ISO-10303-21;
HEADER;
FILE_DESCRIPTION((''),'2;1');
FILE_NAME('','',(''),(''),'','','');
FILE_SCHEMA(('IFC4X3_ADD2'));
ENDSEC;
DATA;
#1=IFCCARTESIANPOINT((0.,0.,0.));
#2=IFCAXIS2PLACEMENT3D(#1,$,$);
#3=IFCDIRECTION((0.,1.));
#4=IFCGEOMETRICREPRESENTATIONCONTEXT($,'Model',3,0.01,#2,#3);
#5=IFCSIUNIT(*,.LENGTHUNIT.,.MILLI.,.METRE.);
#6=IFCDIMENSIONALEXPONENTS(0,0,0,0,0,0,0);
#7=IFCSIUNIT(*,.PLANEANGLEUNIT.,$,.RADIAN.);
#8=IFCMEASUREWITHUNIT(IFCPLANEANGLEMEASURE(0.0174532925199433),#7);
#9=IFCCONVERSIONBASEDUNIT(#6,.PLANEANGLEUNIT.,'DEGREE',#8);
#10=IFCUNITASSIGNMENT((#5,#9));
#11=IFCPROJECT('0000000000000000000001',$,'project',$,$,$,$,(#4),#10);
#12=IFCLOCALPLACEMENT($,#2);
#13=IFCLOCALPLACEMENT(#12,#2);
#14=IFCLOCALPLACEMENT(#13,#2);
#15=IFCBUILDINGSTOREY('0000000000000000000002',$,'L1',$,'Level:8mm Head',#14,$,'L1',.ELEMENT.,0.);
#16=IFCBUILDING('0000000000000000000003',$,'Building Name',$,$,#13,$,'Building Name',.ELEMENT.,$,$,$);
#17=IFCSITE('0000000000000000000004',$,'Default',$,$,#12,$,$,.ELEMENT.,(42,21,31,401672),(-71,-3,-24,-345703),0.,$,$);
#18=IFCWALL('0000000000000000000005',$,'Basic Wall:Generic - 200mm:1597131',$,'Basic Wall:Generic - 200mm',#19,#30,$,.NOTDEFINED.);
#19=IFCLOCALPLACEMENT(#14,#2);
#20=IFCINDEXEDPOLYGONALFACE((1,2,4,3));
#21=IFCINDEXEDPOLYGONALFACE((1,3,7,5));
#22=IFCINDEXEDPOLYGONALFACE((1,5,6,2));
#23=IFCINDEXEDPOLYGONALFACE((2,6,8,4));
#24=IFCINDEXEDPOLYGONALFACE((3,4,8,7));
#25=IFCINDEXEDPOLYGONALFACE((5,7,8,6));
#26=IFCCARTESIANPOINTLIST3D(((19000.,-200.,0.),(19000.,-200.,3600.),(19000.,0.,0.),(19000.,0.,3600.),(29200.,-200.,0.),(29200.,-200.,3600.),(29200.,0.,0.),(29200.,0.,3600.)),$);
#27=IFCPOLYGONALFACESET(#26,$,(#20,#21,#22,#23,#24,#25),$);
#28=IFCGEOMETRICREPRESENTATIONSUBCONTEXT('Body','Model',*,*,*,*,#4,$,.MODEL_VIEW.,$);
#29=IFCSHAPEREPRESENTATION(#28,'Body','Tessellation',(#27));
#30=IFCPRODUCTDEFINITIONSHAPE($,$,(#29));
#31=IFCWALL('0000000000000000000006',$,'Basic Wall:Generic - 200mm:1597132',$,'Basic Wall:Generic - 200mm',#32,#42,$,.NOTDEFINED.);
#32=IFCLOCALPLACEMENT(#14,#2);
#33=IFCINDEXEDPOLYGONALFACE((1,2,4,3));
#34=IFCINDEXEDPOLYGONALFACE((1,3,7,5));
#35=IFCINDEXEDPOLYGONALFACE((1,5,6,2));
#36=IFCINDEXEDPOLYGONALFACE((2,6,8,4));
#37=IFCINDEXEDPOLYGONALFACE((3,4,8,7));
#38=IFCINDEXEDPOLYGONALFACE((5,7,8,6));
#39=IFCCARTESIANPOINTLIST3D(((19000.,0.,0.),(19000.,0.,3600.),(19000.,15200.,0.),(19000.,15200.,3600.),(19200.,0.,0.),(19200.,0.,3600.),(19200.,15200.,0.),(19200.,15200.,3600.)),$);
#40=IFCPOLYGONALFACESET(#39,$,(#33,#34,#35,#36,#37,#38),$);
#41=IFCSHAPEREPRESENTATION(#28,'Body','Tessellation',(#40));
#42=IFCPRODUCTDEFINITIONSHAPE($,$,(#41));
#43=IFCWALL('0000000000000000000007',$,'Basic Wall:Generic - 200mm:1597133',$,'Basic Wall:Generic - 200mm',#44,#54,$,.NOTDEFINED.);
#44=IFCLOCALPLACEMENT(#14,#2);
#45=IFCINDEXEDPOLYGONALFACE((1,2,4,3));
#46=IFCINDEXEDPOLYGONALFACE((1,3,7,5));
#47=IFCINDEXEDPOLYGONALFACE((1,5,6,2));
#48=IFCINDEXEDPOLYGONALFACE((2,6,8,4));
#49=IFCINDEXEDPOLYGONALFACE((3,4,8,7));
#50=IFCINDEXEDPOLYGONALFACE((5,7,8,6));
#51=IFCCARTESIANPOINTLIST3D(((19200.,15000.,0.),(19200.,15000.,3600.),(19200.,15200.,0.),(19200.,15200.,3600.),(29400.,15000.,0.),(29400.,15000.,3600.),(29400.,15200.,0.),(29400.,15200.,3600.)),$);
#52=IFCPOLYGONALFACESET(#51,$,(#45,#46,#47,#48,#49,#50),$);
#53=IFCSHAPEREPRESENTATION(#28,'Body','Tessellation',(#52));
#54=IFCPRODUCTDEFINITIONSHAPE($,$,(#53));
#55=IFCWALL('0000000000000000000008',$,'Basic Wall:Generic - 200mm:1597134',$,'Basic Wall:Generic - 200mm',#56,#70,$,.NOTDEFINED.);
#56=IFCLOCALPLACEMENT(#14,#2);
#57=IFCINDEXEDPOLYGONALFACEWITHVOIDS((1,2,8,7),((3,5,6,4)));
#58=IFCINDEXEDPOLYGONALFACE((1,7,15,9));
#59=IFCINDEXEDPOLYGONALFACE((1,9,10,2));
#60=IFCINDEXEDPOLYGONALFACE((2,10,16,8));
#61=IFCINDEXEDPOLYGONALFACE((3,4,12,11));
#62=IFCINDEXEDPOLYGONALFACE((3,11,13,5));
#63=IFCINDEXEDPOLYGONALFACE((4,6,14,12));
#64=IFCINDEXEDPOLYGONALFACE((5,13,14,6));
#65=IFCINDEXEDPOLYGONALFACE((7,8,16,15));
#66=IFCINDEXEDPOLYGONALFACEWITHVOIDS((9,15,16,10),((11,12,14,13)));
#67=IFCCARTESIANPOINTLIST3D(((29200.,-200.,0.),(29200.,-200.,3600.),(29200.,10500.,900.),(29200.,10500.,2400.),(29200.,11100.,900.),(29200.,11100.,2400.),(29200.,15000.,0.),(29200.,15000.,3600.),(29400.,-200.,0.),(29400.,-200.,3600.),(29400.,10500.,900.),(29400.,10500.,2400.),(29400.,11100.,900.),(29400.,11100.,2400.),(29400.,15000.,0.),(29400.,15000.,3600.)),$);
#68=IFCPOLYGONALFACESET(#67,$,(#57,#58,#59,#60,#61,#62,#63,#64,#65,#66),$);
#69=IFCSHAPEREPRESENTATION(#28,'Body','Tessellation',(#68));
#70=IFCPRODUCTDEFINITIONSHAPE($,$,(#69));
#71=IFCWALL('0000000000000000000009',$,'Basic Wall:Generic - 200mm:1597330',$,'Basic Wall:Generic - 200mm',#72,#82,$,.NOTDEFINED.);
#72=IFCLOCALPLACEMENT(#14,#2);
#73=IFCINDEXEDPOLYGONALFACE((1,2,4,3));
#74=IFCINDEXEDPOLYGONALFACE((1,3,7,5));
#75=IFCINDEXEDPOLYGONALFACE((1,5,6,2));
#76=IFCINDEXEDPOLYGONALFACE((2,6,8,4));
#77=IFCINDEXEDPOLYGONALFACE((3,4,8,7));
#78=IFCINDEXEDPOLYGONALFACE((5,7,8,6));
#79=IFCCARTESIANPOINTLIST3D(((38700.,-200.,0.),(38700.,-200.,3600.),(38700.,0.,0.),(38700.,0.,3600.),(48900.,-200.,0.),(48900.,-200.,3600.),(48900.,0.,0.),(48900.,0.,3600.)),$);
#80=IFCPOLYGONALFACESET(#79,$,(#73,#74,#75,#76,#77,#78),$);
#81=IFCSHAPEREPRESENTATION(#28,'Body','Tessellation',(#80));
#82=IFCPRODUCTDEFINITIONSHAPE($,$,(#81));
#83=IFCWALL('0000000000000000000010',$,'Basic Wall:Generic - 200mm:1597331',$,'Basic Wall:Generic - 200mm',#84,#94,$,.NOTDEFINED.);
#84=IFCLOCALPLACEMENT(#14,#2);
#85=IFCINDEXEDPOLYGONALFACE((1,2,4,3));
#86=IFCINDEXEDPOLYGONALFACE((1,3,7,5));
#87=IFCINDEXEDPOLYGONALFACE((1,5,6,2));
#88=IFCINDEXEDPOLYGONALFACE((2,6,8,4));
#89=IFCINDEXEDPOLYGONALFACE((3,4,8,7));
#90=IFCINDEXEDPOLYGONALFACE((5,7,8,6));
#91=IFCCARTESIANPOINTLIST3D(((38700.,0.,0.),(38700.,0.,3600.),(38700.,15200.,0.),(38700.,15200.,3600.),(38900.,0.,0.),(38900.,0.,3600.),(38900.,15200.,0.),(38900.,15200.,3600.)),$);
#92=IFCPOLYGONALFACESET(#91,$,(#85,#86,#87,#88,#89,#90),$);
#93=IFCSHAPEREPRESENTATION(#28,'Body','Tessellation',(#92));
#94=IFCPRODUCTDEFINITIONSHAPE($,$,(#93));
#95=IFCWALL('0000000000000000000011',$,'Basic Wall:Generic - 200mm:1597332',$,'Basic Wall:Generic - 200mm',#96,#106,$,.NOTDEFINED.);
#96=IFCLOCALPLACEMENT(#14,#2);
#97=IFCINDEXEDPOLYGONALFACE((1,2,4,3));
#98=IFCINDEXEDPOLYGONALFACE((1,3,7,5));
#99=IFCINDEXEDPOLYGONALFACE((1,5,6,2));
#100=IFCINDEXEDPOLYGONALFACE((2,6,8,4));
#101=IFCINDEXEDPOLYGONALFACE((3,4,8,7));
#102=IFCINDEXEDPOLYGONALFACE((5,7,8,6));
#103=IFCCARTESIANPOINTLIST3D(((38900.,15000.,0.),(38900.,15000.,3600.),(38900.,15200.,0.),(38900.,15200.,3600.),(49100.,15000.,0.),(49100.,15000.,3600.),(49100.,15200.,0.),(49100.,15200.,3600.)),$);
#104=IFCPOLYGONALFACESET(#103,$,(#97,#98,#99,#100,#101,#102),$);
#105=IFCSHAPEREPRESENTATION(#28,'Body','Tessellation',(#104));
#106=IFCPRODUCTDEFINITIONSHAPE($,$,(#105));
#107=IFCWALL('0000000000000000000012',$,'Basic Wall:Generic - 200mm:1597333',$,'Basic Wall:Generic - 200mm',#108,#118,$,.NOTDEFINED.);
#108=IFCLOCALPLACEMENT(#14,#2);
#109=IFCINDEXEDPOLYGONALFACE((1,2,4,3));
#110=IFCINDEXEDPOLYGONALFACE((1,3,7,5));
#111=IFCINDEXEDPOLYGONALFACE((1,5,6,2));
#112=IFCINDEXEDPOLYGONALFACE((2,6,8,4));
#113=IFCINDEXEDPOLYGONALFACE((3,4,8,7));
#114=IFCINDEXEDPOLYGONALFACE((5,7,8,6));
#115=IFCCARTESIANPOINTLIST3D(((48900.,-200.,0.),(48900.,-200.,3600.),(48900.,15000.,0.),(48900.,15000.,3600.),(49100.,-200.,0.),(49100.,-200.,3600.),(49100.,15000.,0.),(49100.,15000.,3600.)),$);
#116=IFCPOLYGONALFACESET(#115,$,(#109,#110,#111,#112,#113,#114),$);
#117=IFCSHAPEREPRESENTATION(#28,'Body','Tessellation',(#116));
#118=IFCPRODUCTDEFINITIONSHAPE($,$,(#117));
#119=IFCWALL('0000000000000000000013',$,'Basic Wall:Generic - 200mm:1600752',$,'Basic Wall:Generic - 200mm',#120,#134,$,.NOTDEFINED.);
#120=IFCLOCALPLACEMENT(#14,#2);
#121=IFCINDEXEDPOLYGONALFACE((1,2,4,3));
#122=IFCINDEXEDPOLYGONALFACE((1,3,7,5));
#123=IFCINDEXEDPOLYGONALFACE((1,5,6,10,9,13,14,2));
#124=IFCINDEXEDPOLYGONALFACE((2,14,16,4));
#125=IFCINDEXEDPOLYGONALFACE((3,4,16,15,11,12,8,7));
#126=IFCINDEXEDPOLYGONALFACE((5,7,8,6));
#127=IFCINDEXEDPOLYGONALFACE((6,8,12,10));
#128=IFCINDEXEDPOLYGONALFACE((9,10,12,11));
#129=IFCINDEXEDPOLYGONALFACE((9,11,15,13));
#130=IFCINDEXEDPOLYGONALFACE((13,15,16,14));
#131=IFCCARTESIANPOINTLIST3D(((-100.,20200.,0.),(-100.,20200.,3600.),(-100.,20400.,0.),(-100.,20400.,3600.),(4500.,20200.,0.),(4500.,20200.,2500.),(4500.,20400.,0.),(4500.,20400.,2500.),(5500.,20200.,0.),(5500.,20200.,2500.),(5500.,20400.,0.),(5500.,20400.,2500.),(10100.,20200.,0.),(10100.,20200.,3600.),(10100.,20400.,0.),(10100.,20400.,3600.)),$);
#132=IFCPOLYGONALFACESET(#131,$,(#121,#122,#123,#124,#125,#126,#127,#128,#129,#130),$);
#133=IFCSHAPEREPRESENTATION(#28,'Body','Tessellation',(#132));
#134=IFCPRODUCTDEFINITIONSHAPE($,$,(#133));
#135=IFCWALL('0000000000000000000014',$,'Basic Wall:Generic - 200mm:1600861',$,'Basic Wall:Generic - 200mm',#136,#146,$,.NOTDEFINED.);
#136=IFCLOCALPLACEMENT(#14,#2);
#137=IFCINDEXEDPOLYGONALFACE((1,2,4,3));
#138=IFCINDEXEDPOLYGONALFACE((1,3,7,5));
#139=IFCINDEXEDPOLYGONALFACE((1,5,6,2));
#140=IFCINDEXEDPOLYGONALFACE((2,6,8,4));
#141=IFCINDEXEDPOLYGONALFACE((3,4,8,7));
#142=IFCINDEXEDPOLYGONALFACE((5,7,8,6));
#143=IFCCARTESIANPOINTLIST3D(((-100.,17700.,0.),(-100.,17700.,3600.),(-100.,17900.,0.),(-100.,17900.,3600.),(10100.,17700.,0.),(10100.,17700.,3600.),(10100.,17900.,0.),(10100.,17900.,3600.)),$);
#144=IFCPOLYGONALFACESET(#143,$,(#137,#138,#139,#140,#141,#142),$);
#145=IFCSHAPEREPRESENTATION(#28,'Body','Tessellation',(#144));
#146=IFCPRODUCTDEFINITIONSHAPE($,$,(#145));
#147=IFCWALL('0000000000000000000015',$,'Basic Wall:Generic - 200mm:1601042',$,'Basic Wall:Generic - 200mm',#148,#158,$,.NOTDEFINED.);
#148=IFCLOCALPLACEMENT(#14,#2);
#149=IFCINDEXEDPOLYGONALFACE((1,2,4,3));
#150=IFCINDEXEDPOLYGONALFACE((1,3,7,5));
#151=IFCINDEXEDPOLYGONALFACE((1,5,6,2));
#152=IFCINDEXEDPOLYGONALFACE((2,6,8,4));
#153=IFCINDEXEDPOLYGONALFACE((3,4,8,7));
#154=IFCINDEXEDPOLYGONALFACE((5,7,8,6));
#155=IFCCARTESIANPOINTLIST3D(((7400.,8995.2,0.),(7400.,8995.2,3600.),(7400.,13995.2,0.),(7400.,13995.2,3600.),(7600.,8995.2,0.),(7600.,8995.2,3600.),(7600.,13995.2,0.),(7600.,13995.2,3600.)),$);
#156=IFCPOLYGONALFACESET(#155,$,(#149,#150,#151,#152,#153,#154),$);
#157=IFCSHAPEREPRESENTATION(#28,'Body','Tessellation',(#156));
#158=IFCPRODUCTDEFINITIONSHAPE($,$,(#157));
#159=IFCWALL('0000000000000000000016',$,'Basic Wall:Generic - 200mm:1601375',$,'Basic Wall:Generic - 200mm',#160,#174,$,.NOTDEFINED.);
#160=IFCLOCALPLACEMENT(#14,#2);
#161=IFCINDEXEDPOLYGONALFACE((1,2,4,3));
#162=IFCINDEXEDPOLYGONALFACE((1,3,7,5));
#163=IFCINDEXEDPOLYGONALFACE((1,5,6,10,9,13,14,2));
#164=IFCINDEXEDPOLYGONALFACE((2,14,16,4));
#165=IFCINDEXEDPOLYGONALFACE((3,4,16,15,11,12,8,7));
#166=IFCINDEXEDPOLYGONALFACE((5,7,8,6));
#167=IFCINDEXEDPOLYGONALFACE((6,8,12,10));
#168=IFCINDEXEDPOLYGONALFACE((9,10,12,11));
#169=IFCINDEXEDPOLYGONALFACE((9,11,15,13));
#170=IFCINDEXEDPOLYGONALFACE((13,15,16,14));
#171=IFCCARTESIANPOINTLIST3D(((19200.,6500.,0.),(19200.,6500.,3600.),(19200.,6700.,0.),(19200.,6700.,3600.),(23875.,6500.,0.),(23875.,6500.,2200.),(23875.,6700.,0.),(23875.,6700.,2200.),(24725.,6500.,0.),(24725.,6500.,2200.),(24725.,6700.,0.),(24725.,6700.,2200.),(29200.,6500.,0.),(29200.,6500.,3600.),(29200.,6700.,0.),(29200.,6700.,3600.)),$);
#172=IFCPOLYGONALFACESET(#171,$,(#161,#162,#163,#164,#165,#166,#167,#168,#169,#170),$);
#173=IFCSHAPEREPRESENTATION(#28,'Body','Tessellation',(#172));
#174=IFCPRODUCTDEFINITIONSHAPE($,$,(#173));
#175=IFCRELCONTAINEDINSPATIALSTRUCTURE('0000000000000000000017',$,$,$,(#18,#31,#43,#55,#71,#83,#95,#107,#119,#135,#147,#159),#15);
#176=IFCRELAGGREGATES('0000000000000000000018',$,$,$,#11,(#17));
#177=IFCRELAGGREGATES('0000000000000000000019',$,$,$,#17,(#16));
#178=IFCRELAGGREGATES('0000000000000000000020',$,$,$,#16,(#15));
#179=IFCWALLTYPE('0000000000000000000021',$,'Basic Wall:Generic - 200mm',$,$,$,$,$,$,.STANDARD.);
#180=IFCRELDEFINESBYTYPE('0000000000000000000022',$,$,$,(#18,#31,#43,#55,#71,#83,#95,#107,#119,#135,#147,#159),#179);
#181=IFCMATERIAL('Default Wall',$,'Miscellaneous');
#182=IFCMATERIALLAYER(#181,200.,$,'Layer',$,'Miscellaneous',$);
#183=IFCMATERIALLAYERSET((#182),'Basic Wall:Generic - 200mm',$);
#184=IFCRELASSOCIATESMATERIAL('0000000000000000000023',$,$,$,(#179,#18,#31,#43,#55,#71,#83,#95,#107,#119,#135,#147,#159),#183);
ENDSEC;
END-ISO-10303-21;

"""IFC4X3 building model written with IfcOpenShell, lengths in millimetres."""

from ifc_helpers import new_model, entity, si_unit, converted_unit, direction, frame, frame_2d, origin, origin_2d_with_axis, place, context, subcontext, project, spatial, rectangle, extrude, material, layer, layer_set, type_object, element, save


model = new_model("IFC4X3")

# Units and contexts
model_context = context("Model", 3, precision=0.01, world=origin(), true_north=direction((0.0, 1.0)))
body_context = subcontext(model_context, "Body", "Model", "MODEL_VIEW")
ifc_project = project(units=[si_unit("LENGTHUNIT", "METRE", prefix="MILLI"), converted_unit("PLANEANGLEUNIT", "DEGREE", entity("IfcPlaneAngleMeasure", 0.0174532925199433), si_unit("PLANEANGLEUNIT", "RADIAN"), dimensions=[0, 0, 0, 0, 0, 0, 0])], contexts=[model_context])

# Site, building, storey
site_placement = place(None, origin())
site = spatial("IfcSite", under=ifc_project, at=site_placement, Name="Default", CompositionType="ELEMENT", RefLatitude=(42, 21, 31, 401672), RefLongitude=(-71, -3, -24, -345703), RefElevation=0.0)
building_placement = place(site_placement, origin())
building = spatial("IfcBuilding", under=site, at=building_placement, Name="Building Name", LongName="Building Name", CompositionType="ELEMENT")
storey_placement = place(building_placement, origin())
storey = spatial("IfcBuildingStorey", under=building, at=storey_placement, Name="L1", ObjectType="Level:8mm Head", LongName="L1", CompositionType="ELEMENT", Elevation=0.0)

# Walls
ifc_material_1 = material(Name="Default Wall", Category="Miscellaneous")
ifc_layer_1 = layer(ifc_material_1, 200.0, Name="Layer", Category="Miscellaneous")
ifc_layer_set_1 = layer_set([ifc_layer_1], Name="Basic Wall:Generic - 200mm")
wall_type_1 = type_object("IfcWallType", Name="Basic Wall:Generic - 200mm", PredefinedType="STANDARD", material=ifc_layer_set_1)
wall_1_placement = place(storey_placement, frame((19000.0, -100.0, 0.0)))
element("IfcWall", 1, at=wall_1_placement, inside=storey, type_object=wall_type_1, material=ifc_layer_set_1, Name="Basic Wall:Generic - 200mm:1597131", ObjectType="Basic Wall:Generic - 200mm", PredefinedType="NOTDEFINED", context=body_context, shape_type="SweptSolid", body=[
    extrude(rectangle(XDim=10200.0, YDim=200.0, at=frame_2d((5100.0, 0.0), x_axis=(-1.0, 0.0))), origin(), (0.0, 0.0, 1.0), 3600.0),
])
wall_2_placement = place(storey_placement, frame((19100.0, 15200.0, 0.0), z_axis=(0.0, 0.0, 1.0), x_axis=(0.0, -1.0, 0.0)))
element("IfcWall", 2, at=wall_2_placement, inside=storey, type_object=wall_type_1, material=ifc_layer_set_1, Name="Basic Wall:Generic - 200mm:1597132", ObjectType="Basic Wall:Generic - 200mm", PredefinedType="NOTDEFINED", context=body_context, shape_type="SweptSolid", body=[
    extrude(rectangle(XDim=15200.0, YDim=200.0, at=frame_2d((7600.0, 0.0), x_axis=(-1.0, 0.0))), origin(), (0.0, 0.0, 1.0), 3600.0),
])
wall_3_placement = place(storey_placement, frame((29400.0, 15100.0, 0.0), z_axis=(0.0, 0.0, 1.0), x_axis=(-1.0, 0.0, 0.0)))
element("IfcWall", 3, at=wall_3_placement, inside=storey, type_object=wall_type_1, material=ifc_layer_set_1, Name="Basic Wall:Generic - 200mm:1597133", ObjectType="Basic Wall:Generic - 200mm", PredefinedType="NOTDEFINED", context=body_context, shape_type="SweptSolid", body=[
    extrude(rectangle(XDim=10200.0, YDim=200.0, at=frame_2d((5100.0, 0.0), x_axis=(-1.0, 0.0))), origin(), (0.0, 0.0, 1.0), 3600.0),
])

# Wall, opening
wall_4_placement = place(storey_placement, frame((29300.0, -200.0, 0.0), z_axis=(0.0, 0.0, 1.0), x_axis=(0.0, 1.0, 0.0)))
wall_4 = element("IfcWall", 4, at=wall_4_placement, inside=storey, type_object=wall_type_1, material=ifc_layer_set_1, Name="Basic Wall:Generic - 200mm:1597134", ObjectType="Basic Wall:Generic - 200mm", PredefinedType="NOTDEFINED", context=body_context, shape_type="SweptSolid", body=[
    extrude(rectangle(XDim=15200.0, YDim=200.0, at=frame_2d((7600.0, 0.0), x_axis=(-1.0, 0.0))), origin(), (0.0, 0.0, 1.0), 3600.0),
])
opening_1_placement = place(wall_4_placement, frame((11300.0, 100.0, 900.0)))
element("IfcOpeningElement", 5, at=opening_1_placement, cuts=wall_4, PredefinedType="OPENING", context=body_context, shape_type="SweptSolid", body=[
    extrude(rectangle(XDim=1500.0, YDim=600.0, at=frame_2d((750.0, 300.0), x_axis=(-1.0, 0.0))), frame((0.0, 0.0, 0.0), z_axis=(0.0, -1.0, 0.0), x_axis=(0.0, 0.0, 1.0)), (0.0, 0.0, 1.0), 200.0),
])

# Walls
wall_5_placement = place(storey_placement, frame((38700.0, -100.0, 0.0)))
element("IfcWall", 6, at=wall_5_placement, inside=storey, type_object=wall_type_1, material=ifc_layer_set_1, Name="Basic Wall:Generic - 200mm:1597330", ObjectType="Basic Wall:Generic - 200mm", PredefinedType="NOTDEFINED", context=body_context, shape_type="SweptSolid", body=[
    extrude(rectangle(XDim=10200.0, YDim=200.0, at=frame_2d((5100.0, 0.0), x_axis=(-1.0, 0.0))), origin(), (0.0, 0.0, 1.0), 3600.0),
])
wall_6_placement = place(storey_placement, frame((38800.0, 15200.0, 0.0), z_axis=(0.0, 0.0, 1.0), x_axis=(0.0, -1.0, 0.0)))
element("IfcWall", 7, at=wall_6_placement, inside=storey, type_object=wall_type_1, material=ifc_layer_set_1, Name="Basic Wall:Generic - 200mm:1597331", ObjectType="Basic Wall:Generic - 200mm", PredefinedType="NOTDEFINED", context=body_context, shape_type="SweptSolid", body=[
    extrude(rectangle(XDim=15200.0, YDim=200.0, at=frame_2d((7600.0, 0.0), x_axis=(-1.0, 0.0))), origin(), (0.0, 0.0, 1.0), 3600.0),
])
wall_7_placement = place(storey_placement, frame((49100.0, 15100.0, 0.0), z_axis=(0.0, 0.0, 1.0), x_axis=(-1.0, 0.0, 0.0)))
element("IfcWall", 8, at=wall_7_placement, inside=storey, type_object=wall_type_1, material=ifc_layer_set_1, Name="Basic Wall:Generic - 200mm:1597332", ObjectType="Basic Wall:Generic - 200mm", PredefinedType="NOTDEFINED", context=body_context, shape_type="SweptSolid", body=[
    extrude(rectangle(XDim=10200.0, YDim=200.0, at=frame_2d((5100.0, 0.0), x_axis=(-1.0, 0.0))), origin(), (0.0, 0.0, 1.0), 3600.0),
])
wall_8_placement = place(storey_placement, frame((49000.0, -200.0, 0.0), z_axis=(0.0, 0.0, 1.0), x_axis=(0.0, 1.0, 0.0)))
element("IfcWall", 9, at=wall_8_placement, inside=storey, type_object=wall_type_1, material=ifc_layer_set_1, Name="Basic Wall:Generic - 200mm:1597333", ObjectType="Basic Wall:Generic - 200mm", PredefinedType="NOTDEFINED", context=body_context, shape_type="SweptSolid", body=[
    extrude(rectangle(XDim=15200.0, YDim=200.0, at=frame_2d((7600.0, 0.0), x_axis=(-1.0, 0.0))), origin(), (0.0, 0.0, 1.0), 3600.0),
])

# Wall, opening
wall_9_placement = place(storey_placement, frame((10100.0, 20300.0, 0.0), z_axis=(0.0, 0.0, 1.0), x_axis=(-1.0, 0.0, 0.0)))
wall_9 = element("IfcWall", 10, at=wall_9_placement, inside=storey, type_object=wall_type_1, material=ifc_layer_set_1, Name="Basic Wall:Generic - 200mm:1600752", ObjectType="Basic Wall:Generic - 200mm", PredefinedType="NOTDEFINED", context=body_context, shape_type="SweptSolid", body=[
    extrude(rectangle(XDim=10200.0, YDim=200.0, at=frame_2d((5100.0, 0.0), x_axis=(1.0, 0.0))), origin(), (0.0, 0.0, 1.0), 3600.0),
])
opening_2_placement = place(wall_9_placement, frame((5600.0, 100.0, 0.0)))
element("IfcOpeningElement", 11, at=opening_2_placement, cuts=wall_9, PredefinedType="OPENING", context=body_context, shape_type="SweptSolid", body=[
    extrude(rectangle(XDim=2500.0, YDim=1000.0, at=origin_2d_with_axis()), frame((-500.0, -200.0, 1250.0), z_axis=(0.0, 1.0, 0.0), x_axis=(0.0, 0.0, -1.0)), (0.0, 0.0, 1.0), 200.0),
])

# Walls
wall_10_placement = place(storey_placement, frame((10100.0, 17800.0, 0.0), z_axis=(0.0, 0.0, 1.0), x_axis=(-1.0, 0.0, 0.0)))
element("IfcWall", 12, at=wall_10_placement, inside=storey, type_object=wall_type_1, material=ifc_layer_set_1, Name="Basic Wall:Generic - 200mm:1600861", ObjectType="Basic Wall:Generic - 200mm", PredefinedType="NOTDEFINED", context=body_context, shape_type="SweptSolid", body=[
    extrude(rectangle(XDim=10200.0, YDim=200.0, at=frame_2d((5100.0, 0.0), x_axis=(-1.0, 0.0))), origin(), (0.0, 0.0, 1.0), 3600.0),
])
wall_11_placement = place(storey_placement, frame((7500.0, 13995.2, 0.0), z_axis=(0.0, 0.0, 1.0), x_axis=(0.0, -1.0, 0.0)))
element("IfcWall", 13, at=wall_11_placement, inside=storey, type_object=wall_type_1, material=ifc_layer_set_1, Name="Basic Wall:Generic - 200mm:1601042", ObjectType="Basic Wall:Generic - 200mm", PredefinedType="NOTDEFINED", context=body_context, shape_type="SweptSolid", body=[
    extrude(rectangle(XDim=5000.0, YDim=200.0, at=frame_2d((2500.0, 0.0), x_axis=(-1.0, 0.0))), origin(), (0.0, 0.0, 1.0), 3600.0),
])

# Wall, opening
wall_12_placement = place(storey_placement, frame((29200.0, 6600.0, 0.0), z_axis=(0.0, 0.0, 1.0), x_axis=(-1.0, 0.0, 0.0)))
wall_12 = element("IfcWall", 14, at=wall_12_placement, inside=storey, type_object=wall_type_1, material=ifc_layer_set_1, Name="Basic Wall:Generic - 200mm:1601375", ObjectType="Basic Wall:Generic - 200mm", PredefinedType="NOTDEFINED", context=body_context, shape_type="SweptSolid", body=[
    extrude(rectangle(XDim=10000.0, YDim=200.0, at=frame_2d((5000.0, 0.0), x_axis=(1.0, 0.0))), origin(), (0.0, 0.0, 1.0), 3600.0),
])
opening_3_placement = place(wall_12_placement, frame((5325.0, 100.0, 0.0)))
element("IfcOpeningElement", 15, at=opening_3_placement, cuts=wall_12, PredefinedType="OPENING", context=body_context, shape_type="SweptSolid", body=[
    extrude(rectangle(XDim=2200.0, YDim=850.0, at=frame_2d((1100.0, 425.0), x_axis=(1.0, 0.0))), frame((0.0, 0.0, 0.0), z_axis=(0.0, -1.0, 0.0), x_axis=(0.0, 0.0, 1.0)), (0.0, 0.0, 1.0), 200.0),
])

save(model, "model.ifc")
